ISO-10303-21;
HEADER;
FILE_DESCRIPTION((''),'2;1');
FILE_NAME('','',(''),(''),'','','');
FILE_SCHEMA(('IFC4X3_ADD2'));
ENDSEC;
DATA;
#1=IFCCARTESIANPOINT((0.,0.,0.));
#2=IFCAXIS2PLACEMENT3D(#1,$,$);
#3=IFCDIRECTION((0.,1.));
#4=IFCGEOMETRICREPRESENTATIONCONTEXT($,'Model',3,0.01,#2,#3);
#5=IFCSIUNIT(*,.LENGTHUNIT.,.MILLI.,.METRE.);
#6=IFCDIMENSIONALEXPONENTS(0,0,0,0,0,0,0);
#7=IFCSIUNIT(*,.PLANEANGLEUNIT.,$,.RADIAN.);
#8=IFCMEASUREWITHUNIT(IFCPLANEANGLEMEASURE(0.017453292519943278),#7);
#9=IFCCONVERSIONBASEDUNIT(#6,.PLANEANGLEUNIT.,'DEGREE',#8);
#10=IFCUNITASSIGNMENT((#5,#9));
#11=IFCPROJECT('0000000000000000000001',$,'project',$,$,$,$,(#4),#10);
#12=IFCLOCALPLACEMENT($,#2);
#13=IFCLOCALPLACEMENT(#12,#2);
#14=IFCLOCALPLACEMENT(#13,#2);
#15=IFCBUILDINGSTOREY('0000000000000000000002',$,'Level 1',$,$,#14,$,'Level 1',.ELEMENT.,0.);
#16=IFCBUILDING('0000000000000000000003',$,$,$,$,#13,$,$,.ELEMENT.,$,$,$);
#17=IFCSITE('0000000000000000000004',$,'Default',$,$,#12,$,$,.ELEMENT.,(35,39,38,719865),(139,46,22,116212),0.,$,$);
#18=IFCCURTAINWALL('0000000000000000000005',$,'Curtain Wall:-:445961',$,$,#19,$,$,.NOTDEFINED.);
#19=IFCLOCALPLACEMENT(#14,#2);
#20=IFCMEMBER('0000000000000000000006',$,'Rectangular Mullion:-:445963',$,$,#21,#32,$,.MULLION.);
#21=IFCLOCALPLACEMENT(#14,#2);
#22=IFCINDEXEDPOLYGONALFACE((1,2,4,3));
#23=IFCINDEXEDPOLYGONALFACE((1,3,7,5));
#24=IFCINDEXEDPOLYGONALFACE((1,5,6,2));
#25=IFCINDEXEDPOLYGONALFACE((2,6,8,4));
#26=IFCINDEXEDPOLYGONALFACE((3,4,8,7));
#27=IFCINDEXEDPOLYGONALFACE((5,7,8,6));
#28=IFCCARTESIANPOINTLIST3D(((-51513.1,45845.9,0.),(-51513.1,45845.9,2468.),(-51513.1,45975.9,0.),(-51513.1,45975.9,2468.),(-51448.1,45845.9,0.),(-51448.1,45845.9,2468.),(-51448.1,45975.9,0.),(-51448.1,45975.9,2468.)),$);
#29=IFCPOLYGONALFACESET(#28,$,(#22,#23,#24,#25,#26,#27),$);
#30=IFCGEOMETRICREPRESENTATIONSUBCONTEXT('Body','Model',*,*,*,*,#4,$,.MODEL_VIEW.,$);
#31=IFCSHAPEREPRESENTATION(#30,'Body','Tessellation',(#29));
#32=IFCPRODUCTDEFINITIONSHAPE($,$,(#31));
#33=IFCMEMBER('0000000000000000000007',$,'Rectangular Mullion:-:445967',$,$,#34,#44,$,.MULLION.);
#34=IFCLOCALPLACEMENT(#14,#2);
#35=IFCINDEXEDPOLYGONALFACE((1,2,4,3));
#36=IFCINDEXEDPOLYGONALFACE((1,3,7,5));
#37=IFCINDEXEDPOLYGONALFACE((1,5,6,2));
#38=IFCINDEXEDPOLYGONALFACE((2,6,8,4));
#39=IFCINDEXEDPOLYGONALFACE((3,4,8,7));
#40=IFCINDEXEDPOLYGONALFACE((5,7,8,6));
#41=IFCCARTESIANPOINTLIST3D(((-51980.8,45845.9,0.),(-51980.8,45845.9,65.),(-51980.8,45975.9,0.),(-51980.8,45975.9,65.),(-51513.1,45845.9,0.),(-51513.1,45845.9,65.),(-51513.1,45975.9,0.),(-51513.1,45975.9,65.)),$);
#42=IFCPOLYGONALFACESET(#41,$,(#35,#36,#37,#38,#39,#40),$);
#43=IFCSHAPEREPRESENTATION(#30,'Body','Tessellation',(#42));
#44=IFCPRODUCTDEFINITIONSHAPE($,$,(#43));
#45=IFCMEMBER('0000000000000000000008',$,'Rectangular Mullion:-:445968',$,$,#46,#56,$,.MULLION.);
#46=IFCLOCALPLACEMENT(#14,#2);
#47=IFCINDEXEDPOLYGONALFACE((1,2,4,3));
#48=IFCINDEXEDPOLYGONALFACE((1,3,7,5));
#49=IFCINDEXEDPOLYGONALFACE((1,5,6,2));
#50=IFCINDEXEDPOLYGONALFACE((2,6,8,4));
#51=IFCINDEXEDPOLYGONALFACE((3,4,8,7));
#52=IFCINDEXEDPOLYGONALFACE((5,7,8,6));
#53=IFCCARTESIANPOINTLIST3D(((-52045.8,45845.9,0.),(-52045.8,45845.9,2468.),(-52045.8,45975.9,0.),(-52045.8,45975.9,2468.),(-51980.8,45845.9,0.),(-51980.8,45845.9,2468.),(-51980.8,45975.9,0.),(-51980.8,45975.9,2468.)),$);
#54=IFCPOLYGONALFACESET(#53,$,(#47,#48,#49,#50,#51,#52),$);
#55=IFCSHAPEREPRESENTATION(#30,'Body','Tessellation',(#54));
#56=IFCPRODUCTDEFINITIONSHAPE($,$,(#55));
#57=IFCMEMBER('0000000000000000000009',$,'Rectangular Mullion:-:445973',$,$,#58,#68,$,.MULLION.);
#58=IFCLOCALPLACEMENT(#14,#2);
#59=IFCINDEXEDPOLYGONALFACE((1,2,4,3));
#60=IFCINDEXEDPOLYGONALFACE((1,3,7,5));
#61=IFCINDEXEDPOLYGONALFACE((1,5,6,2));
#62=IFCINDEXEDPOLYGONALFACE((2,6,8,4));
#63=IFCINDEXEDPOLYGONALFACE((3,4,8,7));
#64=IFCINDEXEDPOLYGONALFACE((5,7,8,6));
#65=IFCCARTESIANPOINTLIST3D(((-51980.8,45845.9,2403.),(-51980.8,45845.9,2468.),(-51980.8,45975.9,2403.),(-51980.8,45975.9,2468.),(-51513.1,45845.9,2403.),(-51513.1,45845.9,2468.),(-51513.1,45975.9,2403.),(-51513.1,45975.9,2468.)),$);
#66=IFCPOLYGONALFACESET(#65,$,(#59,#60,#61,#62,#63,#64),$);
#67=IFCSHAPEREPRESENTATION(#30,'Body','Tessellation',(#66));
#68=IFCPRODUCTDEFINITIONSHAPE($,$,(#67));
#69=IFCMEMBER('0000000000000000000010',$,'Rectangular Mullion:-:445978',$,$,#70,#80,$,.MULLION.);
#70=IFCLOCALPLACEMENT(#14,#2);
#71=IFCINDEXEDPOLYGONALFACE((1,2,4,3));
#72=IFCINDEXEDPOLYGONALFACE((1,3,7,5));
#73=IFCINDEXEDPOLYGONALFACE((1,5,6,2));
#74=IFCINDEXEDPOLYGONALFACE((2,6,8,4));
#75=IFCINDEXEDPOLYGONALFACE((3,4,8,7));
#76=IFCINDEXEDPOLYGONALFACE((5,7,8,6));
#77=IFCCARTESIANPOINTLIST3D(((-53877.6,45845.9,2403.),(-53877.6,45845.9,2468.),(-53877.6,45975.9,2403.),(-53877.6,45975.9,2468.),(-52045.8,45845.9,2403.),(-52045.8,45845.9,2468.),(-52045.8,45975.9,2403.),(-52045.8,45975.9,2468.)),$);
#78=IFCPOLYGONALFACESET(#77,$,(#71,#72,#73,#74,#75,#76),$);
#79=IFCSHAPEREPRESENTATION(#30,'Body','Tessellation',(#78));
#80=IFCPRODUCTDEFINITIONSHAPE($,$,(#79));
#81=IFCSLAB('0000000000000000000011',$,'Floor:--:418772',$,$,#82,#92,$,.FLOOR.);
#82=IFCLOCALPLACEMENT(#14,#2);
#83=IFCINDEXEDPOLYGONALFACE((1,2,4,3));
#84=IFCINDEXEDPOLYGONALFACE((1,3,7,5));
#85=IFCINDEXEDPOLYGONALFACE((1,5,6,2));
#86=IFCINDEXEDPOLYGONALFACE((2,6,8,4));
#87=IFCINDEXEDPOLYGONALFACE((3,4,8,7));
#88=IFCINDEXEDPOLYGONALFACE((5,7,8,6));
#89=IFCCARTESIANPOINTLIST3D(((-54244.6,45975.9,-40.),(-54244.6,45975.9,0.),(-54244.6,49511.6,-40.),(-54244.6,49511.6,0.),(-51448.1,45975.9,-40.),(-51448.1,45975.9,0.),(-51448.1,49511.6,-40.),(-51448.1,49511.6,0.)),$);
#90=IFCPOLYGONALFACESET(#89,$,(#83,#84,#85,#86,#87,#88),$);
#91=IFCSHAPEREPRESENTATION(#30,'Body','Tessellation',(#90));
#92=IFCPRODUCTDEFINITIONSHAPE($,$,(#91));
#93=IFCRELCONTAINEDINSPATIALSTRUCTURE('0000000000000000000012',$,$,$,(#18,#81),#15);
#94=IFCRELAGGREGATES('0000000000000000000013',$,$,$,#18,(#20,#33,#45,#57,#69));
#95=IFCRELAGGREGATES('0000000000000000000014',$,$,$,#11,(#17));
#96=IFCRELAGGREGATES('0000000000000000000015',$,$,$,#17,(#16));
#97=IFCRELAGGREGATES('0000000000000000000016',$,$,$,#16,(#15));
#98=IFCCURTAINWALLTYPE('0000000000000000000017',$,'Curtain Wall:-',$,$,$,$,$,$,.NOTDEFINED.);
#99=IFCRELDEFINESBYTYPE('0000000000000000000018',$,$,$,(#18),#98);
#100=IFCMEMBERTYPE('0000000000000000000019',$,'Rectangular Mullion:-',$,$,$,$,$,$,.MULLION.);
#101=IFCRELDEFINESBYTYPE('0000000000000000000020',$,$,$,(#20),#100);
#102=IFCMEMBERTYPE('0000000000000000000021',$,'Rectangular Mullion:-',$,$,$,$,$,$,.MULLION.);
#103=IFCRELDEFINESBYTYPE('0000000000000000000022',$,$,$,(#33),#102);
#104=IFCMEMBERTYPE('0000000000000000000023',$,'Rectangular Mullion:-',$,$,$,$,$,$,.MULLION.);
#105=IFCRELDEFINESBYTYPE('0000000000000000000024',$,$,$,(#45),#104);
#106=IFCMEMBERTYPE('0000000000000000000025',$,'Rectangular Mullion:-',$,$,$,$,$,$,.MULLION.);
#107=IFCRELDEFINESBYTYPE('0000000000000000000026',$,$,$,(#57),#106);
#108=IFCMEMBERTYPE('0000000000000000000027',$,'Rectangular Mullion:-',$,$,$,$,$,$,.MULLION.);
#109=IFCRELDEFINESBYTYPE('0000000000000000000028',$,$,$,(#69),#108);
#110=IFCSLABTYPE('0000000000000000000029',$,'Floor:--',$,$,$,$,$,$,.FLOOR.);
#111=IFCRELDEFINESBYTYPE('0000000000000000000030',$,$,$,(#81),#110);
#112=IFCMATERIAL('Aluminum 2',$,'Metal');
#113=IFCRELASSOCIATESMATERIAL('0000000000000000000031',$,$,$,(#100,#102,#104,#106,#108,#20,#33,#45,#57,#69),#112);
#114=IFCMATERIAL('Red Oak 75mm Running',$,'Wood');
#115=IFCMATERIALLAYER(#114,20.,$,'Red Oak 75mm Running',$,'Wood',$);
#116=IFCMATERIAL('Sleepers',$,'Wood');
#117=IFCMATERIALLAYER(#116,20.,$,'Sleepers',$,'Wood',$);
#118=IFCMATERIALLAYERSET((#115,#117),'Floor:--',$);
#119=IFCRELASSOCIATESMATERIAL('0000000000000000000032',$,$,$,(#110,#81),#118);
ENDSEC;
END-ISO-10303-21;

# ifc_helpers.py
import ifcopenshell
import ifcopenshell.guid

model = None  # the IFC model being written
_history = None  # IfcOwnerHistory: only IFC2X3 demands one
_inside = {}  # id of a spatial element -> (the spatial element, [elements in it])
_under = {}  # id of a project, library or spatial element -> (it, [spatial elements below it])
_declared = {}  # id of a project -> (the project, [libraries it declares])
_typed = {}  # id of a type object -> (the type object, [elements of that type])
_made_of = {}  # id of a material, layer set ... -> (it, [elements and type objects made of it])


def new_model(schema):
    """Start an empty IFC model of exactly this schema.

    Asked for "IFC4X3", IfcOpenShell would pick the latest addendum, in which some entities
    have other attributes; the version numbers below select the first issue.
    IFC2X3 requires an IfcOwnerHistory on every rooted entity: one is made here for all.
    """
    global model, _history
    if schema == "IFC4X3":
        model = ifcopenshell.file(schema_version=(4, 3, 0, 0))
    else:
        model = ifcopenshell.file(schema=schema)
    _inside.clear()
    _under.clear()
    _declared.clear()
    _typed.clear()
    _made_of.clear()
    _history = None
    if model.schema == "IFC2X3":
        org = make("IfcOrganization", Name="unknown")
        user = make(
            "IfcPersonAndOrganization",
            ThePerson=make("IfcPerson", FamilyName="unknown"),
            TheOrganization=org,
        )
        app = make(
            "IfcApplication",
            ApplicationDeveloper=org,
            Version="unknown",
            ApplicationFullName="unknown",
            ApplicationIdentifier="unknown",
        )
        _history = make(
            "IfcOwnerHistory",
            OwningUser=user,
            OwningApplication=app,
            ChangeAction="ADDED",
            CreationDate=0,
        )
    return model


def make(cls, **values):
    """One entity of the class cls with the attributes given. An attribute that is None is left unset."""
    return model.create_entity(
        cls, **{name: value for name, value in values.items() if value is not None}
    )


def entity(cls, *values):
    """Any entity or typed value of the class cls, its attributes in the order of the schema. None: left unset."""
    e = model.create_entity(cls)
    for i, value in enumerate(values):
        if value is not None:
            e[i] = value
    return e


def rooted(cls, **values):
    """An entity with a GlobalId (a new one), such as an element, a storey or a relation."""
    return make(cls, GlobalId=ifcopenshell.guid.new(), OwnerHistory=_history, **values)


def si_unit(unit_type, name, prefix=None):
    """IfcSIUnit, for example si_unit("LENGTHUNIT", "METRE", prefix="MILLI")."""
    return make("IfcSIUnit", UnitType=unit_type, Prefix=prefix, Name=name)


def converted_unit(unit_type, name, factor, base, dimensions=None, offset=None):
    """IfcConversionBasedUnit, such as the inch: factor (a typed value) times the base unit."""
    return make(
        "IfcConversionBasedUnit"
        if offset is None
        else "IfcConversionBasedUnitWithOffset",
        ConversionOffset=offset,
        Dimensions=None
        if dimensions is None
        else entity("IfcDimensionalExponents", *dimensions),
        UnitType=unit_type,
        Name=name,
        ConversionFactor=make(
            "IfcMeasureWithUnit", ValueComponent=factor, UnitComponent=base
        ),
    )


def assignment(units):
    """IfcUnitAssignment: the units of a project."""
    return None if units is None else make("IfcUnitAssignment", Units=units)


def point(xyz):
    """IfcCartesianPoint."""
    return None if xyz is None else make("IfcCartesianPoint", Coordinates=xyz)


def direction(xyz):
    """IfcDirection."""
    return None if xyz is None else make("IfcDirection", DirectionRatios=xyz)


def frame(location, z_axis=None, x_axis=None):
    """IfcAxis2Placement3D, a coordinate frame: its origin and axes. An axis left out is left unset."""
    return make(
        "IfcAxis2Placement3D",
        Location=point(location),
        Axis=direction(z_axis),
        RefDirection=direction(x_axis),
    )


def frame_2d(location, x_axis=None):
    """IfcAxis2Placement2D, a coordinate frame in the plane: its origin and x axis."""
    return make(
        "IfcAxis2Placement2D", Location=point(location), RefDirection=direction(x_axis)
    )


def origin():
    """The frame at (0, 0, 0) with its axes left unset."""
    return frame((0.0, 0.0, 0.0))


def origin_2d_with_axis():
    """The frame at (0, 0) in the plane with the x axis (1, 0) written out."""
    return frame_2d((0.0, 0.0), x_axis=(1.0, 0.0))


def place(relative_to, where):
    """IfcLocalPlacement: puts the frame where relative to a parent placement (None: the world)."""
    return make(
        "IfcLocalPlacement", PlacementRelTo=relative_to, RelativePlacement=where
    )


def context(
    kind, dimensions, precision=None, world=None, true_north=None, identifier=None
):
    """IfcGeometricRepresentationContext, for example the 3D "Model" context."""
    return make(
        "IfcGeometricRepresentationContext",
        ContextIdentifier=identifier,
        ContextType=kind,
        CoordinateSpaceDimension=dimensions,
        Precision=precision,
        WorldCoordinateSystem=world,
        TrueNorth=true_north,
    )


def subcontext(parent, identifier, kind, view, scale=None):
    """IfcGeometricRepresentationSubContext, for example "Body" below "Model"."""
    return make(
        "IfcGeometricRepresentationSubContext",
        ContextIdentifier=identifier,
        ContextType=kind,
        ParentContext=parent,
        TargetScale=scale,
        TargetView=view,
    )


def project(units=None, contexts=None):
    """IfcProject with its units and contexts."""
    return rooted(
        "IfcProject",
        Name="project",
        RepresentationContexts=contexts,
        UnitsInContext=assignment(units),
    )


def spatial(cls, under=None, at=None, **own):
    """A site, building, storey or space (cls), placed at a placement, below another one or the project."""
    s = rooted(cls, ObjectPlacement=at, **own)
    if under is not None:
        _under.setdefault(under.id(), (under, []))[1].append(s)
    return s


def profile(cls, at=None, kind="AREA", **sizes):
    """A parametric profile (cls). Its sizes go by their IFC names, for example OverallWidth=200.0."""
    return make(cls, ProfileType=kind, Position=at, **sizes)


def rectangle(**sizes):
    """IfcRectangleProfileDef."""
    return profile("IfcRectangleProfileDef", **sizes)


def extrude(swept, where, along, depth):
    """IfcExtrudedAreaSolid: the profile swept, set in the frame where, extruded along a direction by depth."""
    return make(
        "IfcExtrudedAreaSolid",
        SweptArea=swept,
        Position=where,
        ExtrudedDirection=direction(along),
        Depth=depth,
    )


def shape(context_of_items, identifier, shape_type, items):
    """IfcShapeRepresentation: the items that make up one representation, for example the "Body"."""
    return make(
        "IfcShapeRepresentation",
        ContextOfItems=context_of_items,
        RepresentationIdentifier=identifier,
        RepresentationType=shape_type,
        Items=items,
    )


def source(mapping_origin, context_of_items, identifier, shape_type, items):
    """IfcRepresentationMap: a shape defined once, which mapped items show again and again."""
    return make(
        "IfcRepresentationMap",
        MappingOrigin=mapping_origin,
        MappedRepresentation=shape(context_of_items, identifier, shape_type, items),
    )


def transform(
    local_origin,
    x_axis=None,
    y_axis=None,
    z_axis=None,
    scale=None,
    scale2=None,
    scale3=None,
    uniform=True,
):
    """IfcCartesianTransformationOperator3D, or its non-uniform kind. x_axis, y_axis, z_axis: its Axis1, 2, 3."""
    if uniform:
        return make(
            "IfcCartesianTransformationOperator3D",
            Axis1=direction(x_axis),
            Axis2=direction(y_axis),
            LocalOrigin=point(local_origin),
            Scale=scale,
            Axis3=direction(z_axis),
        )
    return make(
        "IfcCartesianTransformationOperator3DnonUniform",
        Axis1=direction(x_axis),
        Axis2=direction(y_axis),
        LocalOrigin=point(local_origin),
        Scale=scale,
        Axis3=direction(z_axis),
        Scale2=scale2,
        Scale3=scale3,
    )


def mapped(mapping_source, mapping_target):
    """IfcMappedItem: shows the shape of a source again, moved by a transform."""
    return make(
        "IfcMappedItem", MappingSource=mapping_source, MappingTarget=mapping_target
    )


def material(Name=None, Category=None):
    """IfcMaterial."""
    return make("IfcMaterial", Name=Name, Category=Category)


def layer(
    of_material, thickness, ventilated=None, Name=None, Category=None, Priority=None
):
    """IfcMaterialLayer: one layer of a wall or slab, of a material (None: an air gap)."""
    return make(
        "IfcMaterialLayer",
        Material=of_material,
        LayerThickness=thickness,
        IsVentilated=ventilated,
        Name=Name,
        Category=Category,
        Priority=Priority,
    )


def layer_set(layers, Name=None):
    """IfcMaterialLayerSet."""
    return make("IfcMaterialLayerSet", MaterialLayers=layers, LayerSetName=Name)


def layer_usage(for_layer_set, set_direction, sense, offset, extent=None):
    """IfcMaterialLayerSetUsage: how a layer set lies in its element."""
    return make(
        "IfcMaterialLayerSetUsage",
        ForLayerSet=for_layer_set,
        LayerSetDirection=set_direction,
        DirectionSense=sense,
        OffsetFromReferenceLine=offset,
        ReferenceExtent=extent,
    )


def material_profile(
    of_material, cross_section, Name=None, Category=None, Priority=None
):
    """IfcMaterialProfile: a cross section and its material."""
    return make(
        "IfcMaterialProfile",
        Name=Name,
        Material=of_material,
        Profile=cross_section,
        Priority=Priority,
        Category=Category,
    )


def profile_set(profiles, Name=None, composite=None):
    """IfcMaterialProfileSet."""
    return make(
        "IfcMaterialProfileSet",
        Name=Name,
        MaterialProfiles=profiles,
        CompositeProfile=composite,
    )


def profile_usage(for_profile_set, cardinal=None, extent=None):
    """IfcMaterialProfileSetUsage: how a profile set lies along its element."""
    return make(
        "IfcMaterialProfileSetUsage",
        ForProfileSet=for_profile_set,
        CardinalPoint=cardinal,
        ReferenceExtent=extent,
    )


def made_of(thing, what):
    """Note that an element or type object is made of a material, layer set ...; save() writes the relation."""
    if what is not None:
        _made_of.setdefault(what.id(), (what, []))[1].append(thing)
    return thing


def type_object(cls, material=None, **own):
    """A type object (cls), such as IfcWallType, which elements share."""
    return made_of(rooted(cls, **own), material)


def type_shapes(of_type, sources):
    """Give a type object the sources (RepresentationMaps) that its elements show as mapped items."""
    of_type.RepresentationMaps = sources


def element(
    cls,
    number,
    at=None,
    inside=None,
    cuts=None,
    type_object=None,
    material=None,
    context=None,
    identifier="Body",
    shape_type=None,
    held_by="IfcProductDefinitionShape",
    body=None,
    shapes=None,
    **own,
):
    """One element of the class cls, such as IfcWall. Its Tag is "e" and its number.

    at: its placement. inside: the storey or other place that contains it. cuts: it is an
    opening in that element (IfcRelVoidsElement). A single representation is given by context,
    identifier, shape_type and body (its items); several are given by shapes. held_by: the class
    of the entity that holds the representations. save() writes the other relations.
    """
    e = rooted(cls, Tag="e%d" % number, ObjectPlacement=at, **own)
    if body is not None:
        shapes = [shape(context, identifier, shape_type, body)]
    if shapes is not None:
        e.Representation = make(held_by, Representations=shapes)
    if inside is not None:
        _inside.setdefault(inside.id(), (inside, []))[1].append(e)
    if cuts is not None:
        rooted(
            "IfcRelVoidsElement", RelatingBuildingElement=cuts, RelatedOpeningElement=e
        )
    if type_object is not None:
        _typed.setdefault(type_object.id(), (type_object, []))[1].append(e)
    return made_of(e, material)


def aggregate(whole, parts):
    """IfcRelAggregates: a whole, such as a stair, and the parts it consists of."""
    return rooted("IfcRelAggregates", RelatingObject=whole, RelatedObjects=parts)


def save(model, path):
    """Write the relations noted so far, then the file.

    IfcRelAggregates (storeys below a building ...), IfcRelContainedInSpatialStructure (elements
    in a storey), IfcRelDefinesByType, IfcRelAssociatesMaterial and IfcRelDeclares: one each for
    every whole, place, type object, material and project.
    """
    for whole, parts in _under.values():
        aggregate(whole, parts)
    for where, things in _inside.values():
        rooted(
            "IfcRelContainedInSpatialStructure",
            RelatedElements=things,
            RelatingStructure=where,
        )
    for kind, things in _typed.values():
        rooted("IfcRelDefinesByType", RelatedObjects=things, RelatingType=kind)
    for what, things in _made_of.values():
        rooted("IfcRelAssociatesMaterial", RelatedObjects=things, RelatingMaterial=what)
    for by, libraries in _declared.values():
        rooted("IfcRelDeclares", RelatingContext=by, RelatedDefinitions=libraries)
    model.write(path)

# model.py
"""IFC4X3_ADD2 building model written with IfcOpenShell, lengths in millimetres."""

from ifc_helpers import new_model, entity, si_unit, converted_unit, direction, frame, frame_2d, origin, origin_2d_with_axis, place, context, subcontext, project, spatial, rectangle, extrude, source, transform, mapped, material, layer, layer_set, layer_usage, material_profile, profile_set, profile_usage, type_object, type_shapes, element, aggregate, save


model = new_model("IFC4X3_ADD2")

# Units and contexts
model_context = context("Model", 3, precision=0.01, world=origin(), true_north=direction((0.0, 1.0)))
body_context = subcontext(model_context, "Body", "Model", "MODEL_VIEW")
ifc_project = project(units=[si_unit("LENGTHUNIT", "METRE", prefix="MILLI"), converted_unit("PLANEANGLEUNIT", "DEGREE", entity("IfcPlaneAngleMeasure", 0.017453292519943278), si_unit("PLANEANGLEUNIT", "RADIAN"), dimensions=[0, 0, 0, 0, 0, 0, 0])], contexts=[model_context])

# Site, building, storey
site_placement = place(None, origin())
site = spatial("IfcSite", under=ifc_project, at=site_placement, Name="Default", CompositionType="ELEMENT", RefLatitude=(35, 39, 38, 719865), RefLongitude=(139, 46, 22, 116212), RefElevation=0.0)
building_placement = place(site_placement, origin())
building = spatial("IfcBuilding", under=site, at=building_placement, CompositionType="ELEMENT")
storey_placement = place(building_placement, origin())
storey = spatial("IfcBuildingStorey", under=building, at=storey_placement, Name="Level 1", LongName="Level 1", CompositionType="ELEMENT", Elevation=0.0)

# Curtain wall, members
curtain_wall_type = type_object("IfcCurtainWallType", Name="Curtain Wall:-", PredefinedType="NOTDEFINED")
curtain_wall_placement = place(storey_placement, origin())
curtain_wall = element("IfcCurtainWall", 1, at=curtain_wall_placement, inside=storey, type_object=curtain_wall_type, Name="Curtain Wall:-:445961", PredefinedType="NOTDEFINED")
ifc_material_1 = material(Name="Aluminum 2", Category="Metal")
ifc_material_profile = material_profile(ifc_material_1, rectangle(XDim=65.0, YDim=130.0, at=origin_2d_with_axis()), Name="-")
ifc_profile_set = profile_set([ifc_material_profile], Name="-")
ifc_profile_usage = profile_usage(ifc_profile_set)
member_type_1 = type_object("IfcMemberType", Name="Rectangular Mullion:-", PredefinedType="MULLION", material=ifc_profile_set)
shared_shape_1 = source(origin(), body_context, "Body", "SweptSolid", [
    extrude(rectangle(XDim=65.0, YDim=130.0, at=origin_2d_with_axis()), frame((-32.5, 0.0, -2468.0), z_axis=(0.0, 0.0, 1.0), x_axis=(-1.0, 0.0, 0.0)), (0.0, 0.0, 1.0), 2468.0),
])
type_shapes(member_type_1, [shared_shape_1])
member_1_placement = place(curtain_wall_placement, frame((-51448.1, 45910.9, 0.0), z_axis=(0.0, 0.0, -1.0), x_axis=(1.0, 0.0, 0.0)))
member_1 = element("IfcMember", 2, at=member_1_placement, type_object=member_type_1, material=ifc_profile_usage, Name="Rectangular Mullion:-:445963", PredefinedType="MULLION", context=body_context, shape_type="MappedRepresentation", body=[
    mapped(shared_shape_1, transform((0.0, 0.0, 0.0), scale=1.0)),
])
member_type_2 = type_object("IfcMemberType", Name="Rectangular Mullion:-", PredefinedType="MULLION", material=ifc_profile_set)
shared_shape_2 = source(origin(), body_context, "Body", "SweptSolid", [
    extrude(rectangle(XDim=65.0, YDim=130.0, at=frame_2d((0.0, 0.0), x_axis=(1.0, 0.0))), frame((-32.5, 0.0, -467.6), z_axis=(0.0, 0.0, 1.0), x_axis=(-1.0, 0.0, 0.0)), (0.0, 0.0, 1.0), 467.6),
])
type_shapes(member_type_2, [shared_shape_2])
member_2_placement = place(curtain_wall_placement, frame((-51980.8, 45910.9, 0.0), z_axis=(-1.0, 0.0, 0.0), x_axis=(0.0, 0.0, -1.0)))
member_2 = element("IfcMember", 3, at=member_2_placement, type_object=member_type_2, material=ifc_profile_usage, Name="Rectangular Mullion:-:445967", PredefinedType="MULLION", context=body_context, shape_type="MappedRepresentation", body=[
    mapped(shared_shape_2, transform((0.0, 0.0, 0.0), scale=1.0)),
])
member_type_3 = type_object("IfcMemberType", Name="Rectangular Mullion:-", PredefinedType="MULLION", material=ifc_profile_set)
shared_shape_3 = source(origin(), body_context, "Body", "SweptSolid", [
    extrude(rectangle(XDim=65.0, YDim=130.0, at=frame_2d((0.0, 0.0), x_axis=(1.0, 0.0))), frame((0.0, 0.0, -2468.0), z_axis=(0.0, 0.0, 1.0), x_axis=(-1.0, 0.0, 0.0)), (0.0, 0.0, 1.0), 2468.0),
])
type_shapes(member_type_3, [shared_shape_3])
member_3_placement = place(curtain_wall_placement, frame((-52013.3, 45910.9, 0.0), z_axis=(0.0, 0.0, -1.0), x_axis=(1.0, 0.0, 0.0)))
member_3 = element("IfcMember", 4, at=member_3_placement, type_object=member_type_3, material=ifc_profile_usage, Name="Rectangular Mullion:-:445968", PredefinedType="MULLION", context=body_context, shape_type="MappedRepresentation", body=[
    mapped(shared_shape_3, transform((0.0, 0.0, 0.0), scale=1.0)),
])
member_type_4 = type_object("IfcMemberType", Name="Rectangular Mullion:-", PredefinedType="MULLION", material=ifc_profile_set)
shared_shape_4 = source(origin(), body_context, "Body", "SweptSolid", [
    extrude(rectangle(XDim=65.0, YDim=130.0, at=origin_2d_with_axis()), frame((0.0, 0.0, -467.6), z_axis=(0.0, 0.0, 1.0), x_axis=(-1.0, 0.0, 0.0)), (0.0, 0.0, 1.0), 467.6),
])
type_shapes(member_type_4, [shared_shape_4])
member_4_placement = place(curtain_wall_placement, frame((-51513.1, 45910.9, 2435.5), z_axis=(1.0, 0.0, 0.0), x_axis=(0.0, 0.0, 1.0)))
member_4 = element("IfcMember", 5, at=member_4_placement, type_object=member_type_4, material=ifc_profile_usage, Name="Rectangular Mullion:-:445973", PredefinedType="MULLION", context=body_context, shape_type="MappedRepresentation", body=[
    mapped(shared_shape_4, transform((0.0, 0.0, 0.0), scale=1.0)),
])
member_type_5 = type_object("IfcMemberType", Name="Rectangular Mullion:-", PredefinedType="MULLION", material=ifc_profile_set)
shared_shape_5 = source(origin(), body_context, "Body", "SweptSolid", [
    extrude(rectangle(XDim=65.0, YDim=130.0, at=origin_2d_with_axis()), frame((0.0, 0.0, -1831.9), z_axis=(0.0, 0.0, 1.0), x_axis=(-1.0, 0.0, 0.0)), (0.0, 0.0, 1.0), 1831.9),
])
type_shapes(member_type_5, [shared_shape_5])
member_5_placement = place(curtain_wall_placement, frame((-52045.8, 45910.9, 2435.5), z_axis=(1.0, 0.0, 0.0), x_axis=(0.0, 0.0, 1.0)))
member_5 = element("IfcMember", 6, at=member_5_placement, type_object=member_type_5, material=ifc_profile_usage, Name="Rectangular Mullion:-:445978", PredefinedType="MULLION", context=body_context, shape_type="MappedRepresentation", body=[
    mapped(shared_shape_5, transform((0.0, 0.0, 0.0), scale=1.0)),
])

# Slab
ifc_material_2 = material(Name="Red Oak 75mm Running", Category="Wood")
ifc_layer_1 = layer(ifc_material_2, 20.0, Name="Red Oak 75mm Running", Category="Wood")
ifc_material_3 = material(Name="Sleepers", Category="Wood")
ifc_layer_2 = layer(ifc_material_3, 20.0, Name="Sleepers", Category="Wood")
ifc_layer_set_1 = layer_set([ifc_layer_1, ifc_layer_2], Name="Floor:--")
ifc_layer_usage_1 = layer_usage(ifc_layer_set_1, "AXIS3", "POSITIVE", 0.0)
slab_type_1 = type_object("IfcSlabType", Name="Floor:--", PredefinedType="FLOOR", material=ifc_layer_set_1)
slab_1_placement = place(storey_placement, origin())
element("IfcSlab", 7, at=slab_1_placement, inside=storey, type_object=slab_type_1, material=ifc_layer_usage_1, Name="Floor:--:418772", PredefinedType="FLOOR", context=body_context, shape_type="SweptSolid", body=[
    extrude(rectangle(XDim=3535.6, YDim=2796.4, at=frame_2d((0.0, 0.0), x_axis=(1.0, 0.0))), frame((-52846.3, 47743.7, 0.0), z_axis=(0.0, 0.0, -1.0), x_axis=(0.0, 1.0, 0.0)), (0.0, 0.0, 1.0), 40.0),
])

aggregate(curtain_wall, [member_1, member_2, member_3, member_4, member_5])

save(model, "model.ifc")
